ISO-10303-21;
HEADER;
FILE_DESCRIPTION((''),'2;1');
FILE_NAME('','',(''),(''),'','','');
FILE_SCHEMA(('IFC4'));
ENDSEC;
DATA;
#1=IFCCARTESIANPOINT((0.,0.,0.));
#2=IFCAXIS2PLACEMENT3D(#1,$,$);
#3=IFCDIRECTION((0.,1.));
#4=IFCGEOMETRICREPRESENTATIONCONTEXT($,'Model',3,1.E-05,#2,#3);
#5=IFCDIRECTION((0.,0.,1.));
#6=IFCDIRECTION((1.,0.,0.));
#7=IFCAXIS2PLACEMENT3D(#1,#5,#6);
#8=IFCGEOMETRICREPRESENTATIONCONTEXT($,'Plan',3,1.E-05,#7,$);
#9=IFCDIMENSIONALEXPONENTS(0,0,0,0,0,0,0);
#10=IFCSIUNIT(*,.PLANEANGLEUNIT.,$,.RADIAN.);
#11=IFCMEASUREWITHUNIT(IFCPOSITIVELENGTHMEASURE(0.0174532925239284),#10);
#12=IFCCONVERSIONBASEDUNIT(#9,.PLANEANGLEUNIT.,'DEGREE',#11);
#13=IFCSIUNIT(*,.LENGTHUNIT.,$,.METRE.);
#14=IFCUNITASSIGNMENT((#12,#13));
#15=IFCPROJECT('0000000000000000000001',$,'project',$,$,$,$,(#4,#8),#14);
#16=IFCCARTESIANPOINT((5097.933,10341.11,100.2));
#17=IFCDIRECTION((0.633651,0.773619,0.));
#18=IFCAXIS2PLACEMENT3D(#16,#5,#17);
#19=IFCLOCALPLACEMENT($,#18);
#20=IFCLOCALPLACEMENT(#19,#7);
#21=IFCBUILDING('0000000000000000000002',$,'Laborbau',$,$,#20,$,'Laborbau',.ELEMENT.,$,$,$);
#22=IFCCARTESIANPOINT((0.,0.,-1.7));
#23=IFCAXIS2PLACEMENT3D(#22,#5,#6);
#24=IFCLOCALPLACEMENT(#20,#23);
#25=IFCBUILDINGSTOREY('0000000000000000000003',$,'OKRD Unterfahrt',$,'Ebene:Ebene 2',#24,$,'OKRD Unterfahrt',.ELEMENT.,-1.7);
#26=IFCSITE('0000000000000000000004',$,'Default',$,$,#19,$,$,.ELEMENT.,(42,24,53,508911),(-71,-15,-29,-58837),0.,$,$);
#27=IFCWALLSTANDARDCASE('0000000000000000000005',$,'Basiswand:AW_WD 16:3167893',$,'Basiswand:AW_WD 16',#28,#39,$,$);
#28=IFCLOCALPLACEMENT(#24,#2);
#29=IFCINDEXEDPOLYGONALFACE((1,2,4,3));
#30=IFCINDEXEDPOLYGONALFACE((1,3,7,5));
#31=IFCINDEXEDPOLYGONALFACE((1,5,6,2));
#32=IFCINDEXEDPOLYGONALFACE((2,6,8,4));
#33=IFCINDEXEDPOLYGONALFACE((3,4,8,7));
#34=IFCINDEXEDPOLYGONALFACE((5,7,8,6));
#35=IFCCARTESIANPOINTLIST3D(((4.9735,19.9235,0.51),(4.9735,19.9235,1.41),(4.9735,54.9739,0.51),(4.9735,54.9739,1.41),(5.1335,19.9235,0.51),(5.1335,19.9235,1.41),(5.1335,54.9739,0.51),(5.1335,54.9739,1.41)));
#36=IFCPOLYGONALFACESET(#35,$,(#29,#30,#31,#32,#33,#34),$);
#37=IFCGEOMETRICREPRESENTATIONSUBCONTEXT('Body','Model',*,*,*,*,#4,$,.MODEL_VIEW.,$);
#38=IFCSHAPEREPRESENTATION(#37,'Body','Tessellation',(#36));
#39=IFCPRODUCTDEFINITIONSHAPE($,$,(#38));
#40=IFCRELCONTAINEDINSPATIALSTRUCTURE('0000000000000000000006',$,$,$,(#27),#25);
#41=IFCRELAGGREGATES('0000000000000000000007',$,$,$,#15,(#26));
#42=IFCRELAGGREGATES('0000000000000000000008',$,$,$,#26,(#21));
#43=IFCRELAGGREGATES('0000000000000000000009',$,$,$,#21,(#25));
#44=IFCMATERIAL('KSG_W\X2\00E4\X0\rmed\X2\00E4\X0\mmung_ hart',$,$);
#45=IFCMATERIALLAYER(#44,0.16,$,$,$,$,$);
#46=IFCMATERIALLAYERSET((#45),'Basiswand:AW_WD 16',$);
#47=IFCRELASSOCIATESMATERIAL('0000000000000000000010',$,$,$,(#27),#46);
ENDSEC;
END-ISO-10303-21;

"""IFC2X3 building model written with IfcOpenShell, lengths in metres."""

from ifc_helpers import new_model, entity, si_unit, converted_unit, direction, frame, frame_2d, origin, origin_with_axes, place, context, subcontext, project, spatial, rectangle, extrude, material, layer, layer_set, layer_usage, element, save


model = new_model("IFC2X3")

# Units and contexts
model_context = context("Model", 3, precision=1e-05, world=origin(), true_north=direction((0.0, 1.0)))
plan_context = context("Plan", 3, precision=1e-05, world=origin_with_axes())
body_context = subcontext(model_context, "Body", "Model", "MODEL_VIEW")
ifc_project = project(units=[converted_unit("PLANEANGLEUNIT", "DEGREE", entity("IfcPositiveLengthMeasure", 0.0174532925239284), si_unit("PLANEANGLEUNIT", "RADIAN"), dimensions=[0, 0, 0, 0, 0, 0, 0]), si_unit("LENGTHUNIT", "METRE")], contexts=[model_context, plan_context])

# Site, building, storey
site_placement = place(None, frame((5097.933, 10341.11, 100.2), z_axis=(0.0, 0.0, 1.0), x_axis=(0.633651, 0.773619, 0.0)))
site = spatial("IfcSite", under=ifc_project, at=site_placement, Name="Default", CompositionType="ELEMENT", RefLatitude=(42, 24, 53, 508911), RefLongitude=(-71, -15, -29, -58837), RefElevation=0.0)
building_placement = place(site_placement, origin_with_axes())
building = spatial("IfcBuilding", under=site, at=building_placement, Name="Laborbau", LongName="Laborbau", CompositionType="ELEMENT")
storey_placement = place(building_placement, frame((0.0, 0.0, -1.7), z_axis=(0.0, 0.0, 1.0), x_axis=(1.0, 0.0, 0.0)))
storey = spatial("IfcBuildingStorey", under=building, at=storey_placement, Name="OKRD Unterfahrt", ObjectType="Ebene:Ebene 2", LongName="OKRD Unterfahrt", CompositionType="ELEMENT", Elevation=-1.7)

# Shared definitions
ifc_material_1 = material(Name="KSG_Wärmedämmung_ hart")

# Wall
ifc_layer_1 = layer(ifc_material_1, 0.16)
ifc_layer_set_1 = layer_set([ifc_layer_1], Name="Basiswand:AW_WD 16")
ifc_layer_usage_1 = layer_usage(ifc_layer_set_1, "AXIS2", "NEGATIVE", 0.08)
wall_placement = place(storey_placement, frame((5.0535, 19.9235, 0.51), z_axis=(0.0, 0.0, 1.0), x_axis=(0.0, 1.0, 0.0)))
element("IfcWallStandardCase", 1, at=wall_placement, inside=storey, material=ifc_layer_usage_1, Name="Basiswand:AW_WD 16:3167893", ObjectType="Basiswand:AW_WD 16", context=body_context, shape_type="SweptSolid", body=[
    extrude(rectangle(XDim=35.0503, YDim=0.16, at=frame_2d((17.5252, 0.0), x_axis=(-1.0, 0.0))), origin(), (0.0, 0.0, 1.0), 0.9),
])

save(model, "model.ifc")
